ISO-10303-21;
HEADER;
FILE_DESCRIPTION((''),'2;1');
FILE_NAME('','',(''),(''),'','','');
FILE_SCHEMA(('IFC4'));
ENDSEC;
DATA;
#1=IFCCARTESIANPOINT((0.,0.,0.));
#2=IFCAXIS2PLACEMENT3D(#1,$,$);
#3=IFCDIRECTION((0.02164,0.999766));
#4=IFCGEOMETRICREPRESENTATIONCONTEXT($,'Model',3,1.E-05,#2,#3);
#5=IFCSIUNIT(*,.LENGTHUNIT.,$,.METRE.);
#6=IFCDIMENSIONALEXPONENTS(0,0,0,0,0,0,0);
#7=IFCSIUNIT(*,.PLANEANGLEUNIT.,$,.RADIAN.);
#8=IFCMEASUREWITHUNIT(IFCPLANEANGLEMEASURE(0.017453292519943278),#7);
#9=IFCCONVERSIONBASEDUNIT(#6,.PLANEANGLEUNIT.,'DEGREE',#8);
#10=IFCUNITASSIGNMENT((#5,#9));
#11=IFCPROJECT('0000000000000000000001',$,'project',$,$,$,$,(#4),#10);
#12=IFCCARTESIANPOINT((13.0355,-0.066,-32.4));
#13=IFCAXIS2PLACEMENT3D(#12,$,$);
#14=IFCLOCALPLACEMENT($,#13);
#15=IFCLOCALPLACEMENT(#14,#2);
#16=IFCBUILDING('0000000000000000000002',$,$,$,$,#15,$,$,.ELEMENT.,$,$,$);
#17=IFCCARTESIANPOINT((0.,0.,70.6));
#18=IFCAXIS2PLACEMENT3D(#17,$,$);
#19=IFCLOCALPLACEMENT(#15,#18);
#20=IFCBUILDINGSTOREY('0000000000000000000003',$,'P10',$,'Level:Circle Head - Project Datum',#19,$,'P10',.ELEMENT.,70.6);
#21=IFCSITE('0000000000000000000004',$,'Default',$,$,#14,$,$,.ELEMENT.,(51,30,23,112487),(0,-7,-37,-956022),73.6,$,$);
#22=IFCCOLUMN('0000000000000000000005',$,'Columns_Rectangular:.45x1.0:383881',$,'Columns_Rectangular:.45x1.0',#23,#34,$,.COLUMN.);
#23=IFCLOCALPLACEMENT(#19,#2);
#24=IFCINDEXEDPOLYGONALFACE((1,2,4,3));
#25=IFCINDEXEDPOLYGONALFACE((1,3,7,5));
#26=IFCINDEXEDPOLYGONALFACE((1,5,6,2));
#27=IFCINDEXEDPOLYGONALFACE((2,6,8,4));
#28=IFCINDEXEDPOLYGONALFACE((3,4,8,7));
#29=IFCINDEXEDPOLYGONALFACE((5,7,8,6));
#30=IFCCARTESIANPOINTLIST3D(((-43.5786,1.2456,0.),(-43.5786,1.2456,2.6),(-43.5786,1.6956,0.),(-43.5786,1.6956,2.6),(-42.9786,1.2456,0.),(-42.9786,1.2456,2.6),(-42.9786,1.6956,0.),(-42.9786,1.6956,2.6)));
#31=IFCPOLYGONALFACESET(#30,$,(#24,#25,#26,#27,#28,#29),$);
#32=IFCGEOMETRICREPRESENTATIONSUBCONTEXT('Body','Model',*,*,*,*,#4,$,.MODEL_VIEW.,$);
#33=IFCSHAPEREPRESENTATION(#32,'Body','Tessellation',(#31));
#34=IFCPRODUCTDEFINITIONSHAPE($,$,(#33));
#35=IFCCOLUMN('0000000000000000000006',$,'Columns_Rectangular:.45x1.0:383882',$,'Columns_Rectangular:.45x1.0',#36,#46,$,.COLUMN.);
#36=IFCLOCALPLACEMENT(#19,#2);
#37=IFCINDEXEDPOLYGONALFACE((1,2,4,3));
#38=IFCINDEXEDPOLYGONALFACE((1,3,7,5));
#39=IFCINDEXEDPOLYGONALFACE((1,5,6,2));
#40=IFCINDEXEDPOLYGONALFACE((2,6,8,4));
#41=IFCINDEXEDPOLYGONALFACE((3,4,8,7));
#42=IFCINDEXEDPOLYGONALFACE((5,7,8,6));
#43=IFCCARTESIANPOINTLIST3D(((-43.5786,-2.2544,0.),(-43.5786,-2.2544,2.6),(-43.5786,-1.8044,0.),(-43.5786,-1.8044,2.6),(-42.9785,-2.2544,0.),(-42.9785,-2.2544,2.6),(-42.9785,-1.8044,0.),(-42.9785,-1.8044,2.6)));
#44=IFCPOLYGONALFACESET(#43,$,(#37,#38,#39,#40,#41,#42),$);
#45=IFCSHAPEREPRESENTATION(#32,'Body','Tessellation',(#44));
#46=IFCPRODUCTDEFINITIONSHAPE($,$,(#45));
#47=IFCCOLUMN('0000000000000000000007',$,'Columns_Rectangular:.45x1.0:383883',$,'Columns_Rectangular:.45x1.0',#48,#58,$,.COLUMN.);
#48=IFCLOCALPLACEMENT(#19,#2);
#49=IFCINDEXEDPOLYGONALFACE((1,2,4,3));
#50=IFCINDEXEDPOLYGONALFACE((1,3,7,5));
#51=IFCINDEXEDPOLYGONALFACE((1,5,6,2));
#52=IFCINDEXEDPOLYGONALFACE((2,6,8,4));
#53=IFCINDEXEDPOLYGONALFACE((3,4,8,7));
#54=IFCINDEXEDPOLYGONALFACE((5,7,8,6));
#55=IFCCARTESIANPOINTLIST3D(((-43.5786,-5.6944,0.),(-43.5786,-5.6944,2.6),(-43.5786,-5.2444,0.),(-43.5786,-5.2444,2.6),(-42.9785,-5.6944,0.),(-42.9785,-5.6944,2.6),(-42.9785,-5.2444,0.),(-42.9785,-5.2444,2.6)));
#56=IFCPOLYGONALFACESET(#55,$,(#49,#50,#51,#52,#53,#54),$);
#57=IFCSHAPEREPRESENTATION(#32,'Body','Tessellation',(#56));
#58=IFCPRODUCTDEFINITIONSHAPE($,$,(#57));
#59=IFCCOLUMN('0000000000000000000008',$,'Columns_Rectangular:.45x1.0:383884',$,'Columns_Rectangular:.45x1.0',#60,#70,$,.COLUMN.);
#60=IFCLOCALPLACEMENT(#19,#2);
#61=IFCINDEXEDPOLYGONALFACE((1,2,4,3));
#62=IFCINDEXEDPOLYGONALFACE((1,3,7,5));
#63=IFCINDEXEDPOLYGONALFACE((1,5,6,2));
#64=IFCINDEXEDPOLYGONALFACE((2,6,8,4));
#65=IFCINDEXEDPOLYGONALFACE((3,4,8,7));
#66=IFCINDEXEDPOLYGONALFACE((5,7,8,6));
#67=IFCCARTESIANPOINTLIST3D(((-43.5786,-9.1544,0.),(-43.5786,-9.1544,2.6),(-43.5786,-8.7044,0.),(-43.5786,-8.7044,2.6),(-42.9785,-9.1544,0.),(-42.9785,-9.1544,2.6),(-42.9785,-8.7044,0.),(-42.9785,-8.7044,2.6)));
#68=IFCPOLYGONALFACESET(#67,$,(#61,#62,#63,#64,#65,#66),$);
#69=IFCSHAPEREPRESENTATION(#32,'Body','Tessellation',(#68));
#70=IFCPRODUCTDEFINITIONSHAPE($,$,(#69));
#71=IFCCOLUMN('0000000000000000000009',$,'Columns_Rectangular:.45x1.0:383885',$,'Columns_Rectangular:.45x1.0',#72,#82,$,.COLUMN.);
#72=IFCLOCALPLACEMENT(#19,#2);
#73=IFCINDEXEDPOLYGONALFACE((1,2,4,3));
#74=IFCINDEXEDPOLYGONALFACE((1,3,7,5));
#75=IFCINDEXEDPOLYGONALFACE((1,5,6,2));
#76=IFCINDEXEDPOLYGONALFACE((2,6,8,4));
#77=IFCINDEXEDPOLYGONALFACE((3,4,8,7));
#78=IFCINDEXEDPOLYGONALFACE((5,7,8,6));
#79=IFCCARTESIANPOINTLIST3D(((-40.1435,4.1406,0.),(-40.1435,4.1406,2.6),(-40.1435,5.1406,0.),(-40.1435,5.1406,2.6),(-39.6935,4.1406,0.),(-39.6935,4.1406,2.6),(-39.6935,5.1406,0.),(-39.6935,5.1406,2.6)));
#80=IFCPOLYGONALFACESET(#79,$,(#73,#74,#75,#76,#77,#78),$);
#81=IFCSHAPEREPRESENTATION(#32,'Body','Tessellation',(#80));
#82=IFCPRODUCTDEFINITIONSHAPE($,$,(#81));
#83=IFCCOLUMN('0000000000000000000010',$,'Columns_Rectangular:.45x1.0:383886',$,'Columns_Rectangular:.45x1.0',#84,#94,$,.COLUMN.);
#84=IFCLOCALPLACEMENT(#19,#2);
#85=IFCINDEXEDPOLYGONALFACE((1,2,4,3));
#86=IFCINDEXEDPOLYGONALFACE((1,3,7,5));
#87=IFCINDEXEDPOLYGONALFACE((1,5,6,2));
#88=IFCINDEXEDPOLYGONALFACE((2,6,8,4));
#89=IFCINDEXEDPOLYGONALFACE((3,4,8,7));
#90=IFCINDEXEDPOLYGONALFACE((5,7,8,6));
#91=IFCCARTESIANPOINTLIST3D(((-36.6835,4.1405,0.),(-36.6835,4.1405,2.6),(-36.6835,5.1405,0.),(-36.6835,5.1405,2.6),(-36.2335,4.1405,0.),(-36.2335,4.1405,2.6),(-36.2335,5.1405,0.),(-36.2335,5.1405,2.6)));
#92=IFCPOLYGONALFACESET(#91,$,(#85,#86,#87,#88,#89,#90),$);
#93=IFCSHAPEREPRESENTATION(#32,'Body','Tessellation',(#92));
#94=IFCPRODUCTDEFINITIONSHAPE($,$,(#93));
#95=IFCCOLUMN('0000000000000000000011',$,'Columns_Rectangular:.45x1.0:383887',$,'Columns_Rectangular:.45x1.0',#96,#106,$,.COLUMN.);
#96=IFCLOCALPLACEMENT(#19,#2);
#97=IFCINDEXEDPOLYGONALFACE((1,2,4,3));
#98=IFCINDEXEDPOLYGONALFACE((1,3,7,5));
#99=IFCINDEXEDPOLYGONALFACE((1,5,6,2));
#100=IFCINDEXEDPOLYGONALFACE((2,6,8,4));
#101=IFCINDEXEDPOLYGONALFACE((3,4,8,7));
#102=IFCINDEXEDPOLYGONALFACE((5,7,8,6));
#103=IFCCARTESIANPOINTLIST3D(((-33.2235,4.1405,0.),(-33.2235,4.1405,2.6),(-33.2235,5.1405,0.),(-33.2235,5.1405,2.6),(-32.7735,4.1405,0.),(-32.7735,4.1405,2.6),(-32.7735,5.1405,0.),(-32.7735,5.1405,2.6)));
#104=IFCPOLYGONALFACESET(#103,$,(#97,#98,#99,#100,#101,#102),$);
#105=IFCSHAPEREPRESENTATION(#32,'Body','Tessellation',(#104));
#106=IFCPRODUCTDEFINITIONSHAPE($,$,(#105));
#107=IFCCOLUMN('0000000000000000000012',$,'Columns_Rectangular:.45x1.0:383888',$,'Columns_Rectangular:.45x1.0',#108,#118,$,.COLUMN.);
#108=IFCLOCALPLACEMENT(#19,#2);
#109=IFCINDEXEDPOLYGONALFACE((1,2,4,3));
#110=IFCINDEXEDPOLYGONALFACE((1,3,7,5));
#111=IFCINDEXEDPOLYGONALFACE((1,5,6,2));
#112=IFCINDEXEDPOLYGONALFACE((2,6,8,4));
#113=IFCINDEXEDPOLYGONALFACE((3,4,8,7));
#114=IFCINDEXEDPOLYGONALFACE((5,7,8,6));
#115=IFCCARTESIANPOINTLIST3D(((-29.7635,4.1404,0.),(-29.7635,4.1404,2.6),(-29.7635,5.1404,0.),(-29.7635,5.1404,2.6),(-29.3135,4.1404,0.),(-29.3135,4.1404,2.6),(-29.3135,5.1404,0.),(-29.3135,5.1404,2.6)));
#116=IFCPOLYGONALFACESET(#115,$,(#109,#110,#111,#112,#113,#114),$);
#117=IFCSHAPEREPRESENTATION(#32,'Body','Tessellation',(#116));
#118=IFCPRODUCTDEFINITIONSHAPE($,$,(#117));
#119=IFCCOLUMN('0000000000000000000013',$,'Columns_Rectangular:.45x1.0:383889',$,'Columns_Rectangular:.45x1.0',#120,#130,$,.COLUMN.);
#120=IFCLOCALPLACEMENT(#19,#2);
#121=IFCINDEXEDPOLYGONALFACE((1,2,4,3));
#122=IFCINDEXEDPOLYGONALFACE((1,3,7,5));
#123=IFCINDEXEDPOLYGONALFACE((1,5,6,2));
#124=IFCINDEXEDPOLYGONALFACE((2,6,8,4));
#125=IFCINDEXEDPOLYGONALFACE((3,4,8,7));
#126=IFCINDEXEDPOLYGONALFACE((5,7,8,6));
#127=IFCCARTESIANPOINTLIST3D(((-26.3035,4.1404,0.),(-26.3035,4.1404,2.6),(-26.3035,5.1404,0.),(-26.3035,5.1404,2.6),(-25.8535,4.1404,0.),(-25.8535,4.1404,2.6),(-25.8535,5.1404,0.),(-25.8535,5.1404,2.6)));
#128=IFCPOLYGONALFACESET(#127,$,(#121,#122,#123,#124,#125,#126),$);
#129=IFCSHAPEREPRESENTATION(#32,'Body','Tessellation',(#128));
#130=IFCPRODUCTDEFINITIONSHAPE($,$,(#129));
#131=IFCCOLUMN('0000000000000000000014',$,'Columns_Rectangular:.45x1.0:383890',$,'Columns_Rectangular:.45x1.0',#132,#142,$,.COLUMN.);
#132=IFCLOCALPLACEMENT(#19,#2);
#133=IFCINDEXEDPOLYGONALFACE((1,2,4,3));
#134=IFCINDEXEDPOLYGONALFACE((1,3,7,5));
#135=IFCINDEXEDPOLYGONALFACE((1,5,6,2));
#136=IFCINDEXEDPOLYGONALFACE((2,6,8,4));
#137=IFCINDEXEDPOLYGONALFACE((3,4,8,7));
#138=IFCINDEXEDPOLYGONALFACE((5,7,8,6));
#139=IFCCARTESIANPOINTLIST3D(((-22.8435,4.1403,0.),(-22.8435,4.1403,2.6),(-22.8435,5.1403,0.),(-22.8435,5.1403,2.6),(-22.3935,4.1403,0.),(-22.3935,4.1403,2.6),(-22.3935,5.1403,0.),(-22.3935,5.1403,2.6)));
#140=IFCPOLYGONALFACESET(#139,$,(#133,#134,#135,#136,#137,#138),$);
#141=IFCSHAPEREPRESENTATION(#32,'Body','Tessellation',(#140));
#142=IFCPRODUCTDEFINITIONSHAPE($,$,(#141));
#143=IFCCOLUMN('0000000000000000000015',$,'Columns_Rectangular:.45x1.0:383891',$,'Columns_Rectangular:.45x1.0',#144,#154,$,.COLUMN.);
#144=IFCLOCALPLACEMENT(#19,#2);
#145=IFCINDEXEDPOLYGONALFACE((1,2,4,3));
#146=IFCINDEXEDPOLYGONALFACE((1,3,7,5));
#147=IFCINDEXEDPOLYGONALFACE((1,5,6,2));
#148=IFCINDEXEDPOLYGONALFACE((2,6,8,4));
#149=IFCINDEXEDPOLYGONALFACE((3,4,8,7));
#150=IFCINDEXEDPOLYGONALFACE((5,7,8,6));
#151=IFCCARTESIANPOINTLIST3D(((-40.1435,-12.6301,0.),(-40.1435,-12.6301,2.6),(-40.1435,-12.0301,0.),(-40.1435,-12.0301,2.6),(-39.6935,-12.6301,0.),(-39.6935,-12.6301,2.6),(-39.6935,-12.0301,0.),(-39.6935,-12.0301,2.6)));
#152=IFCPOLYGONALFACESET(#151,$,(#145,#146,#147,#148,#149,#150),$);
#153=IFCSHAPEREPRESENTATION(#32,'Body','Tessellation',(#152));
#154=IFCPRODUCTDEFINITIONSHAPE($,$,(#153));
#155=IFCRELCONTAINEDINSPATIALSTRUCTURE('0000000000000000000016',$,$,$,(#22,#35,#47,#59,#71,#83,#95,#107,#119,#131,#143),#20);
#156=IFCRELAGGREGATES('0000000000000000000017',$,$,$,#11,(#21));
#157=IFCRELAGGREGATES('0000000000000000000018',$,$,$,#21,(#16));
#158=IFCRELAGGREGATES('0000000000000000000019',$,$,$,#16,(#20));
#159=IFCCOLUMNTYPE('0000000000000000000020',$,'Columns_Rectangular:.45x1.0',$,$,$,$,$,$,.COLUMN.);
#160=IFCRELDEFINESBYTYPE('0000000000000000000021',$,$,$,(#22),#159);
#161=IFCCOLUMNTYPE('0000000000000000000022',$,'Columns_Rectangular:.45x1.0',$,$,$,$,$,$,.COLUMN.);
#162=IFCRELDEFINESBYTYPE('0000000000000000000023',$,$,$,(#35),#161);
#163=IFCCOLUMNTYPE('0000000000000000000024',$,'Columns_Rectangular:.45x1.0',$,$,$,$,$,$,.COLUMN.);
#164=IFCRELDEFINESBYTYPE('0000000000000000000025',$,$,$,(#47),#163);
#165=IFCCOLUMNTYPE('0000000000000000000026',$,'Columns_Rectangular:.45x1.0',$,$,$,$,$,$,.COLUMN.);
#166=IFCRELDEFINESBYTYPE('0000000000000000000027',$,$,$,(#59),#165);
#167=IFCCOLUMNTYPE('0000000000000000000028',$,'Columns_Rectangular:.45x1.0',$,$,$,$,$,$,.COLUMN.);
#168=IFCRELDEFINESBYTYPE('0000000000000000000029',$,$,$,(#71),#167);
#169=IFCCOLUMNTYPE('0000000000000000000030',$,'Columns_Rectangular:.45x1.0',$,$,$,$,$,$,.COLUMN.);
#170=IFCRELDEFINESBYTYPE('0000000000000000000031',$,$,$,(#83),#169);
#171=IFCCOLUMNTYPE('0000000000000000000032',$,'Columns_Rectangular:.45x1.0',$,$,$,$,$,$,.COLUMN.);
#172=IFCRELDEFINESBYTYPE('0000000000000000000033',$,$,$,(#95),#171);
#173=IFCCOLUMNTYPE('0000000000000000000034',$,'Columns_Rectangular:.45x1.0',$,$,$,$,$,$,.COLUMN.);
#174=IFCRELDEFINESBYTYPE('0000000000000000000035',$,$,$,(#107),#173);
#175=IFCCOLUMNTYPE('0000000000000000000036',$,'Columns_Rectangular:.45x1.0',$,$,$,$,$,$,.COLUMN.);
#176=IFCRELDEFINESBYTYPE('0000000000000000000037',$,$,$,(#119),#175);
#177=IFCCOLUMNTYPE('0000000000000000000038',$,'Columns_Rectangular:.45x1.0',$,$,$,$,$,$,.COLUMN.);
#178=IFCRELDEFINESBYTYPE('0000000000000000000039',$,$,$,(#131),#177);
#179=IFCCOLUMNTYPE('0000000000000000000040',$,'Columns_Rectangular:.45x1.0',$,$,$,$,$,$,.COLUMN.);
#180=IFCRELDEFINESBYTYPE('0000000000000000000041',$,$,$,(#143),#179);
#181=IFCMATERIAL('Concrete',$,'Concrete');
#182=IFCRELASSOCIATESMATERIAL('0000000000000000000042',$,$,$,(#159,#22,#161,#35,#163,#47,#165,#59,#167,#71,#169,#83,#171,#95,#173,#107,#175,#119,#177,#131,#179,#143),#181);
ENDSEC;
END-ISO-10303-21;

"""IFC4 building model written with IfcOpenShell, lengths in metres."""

from ifc_helpers import new_model, entity, si_unit, converted_unit, direction, frame, origin, place, context, subcontext, project, spatial, indexed_curve, outline, extrude, source, transform, mapped, material, type_object, type_shapes, element, save


model = new_model("IFC4")

# Units and contexts
model_context = context("Model", 3, precision=1e-05, world=origin(), true_north=direction((0.02164, 0.999766)))
body_context = subcontext(model_context, "Body", "Model", "MODEL_VIEW")
ifc_project = project(units=[si_unit("LENGTHUNIT", "METRE"), converted_unit("PLANEANGLEUNIT", "DEGREE", entity("IfcPlaneAngleMeasure", 0.017453292519943278), si_unit("PLANEANGLEUNIT", "RADIAN"), dimensions=[0, 0, 0, 0, 0, 0, 0])], contexts=[model_context])

# Site, building, storey
site_placement = place(None, frame((13.0355, -0.066, -32.4)))
site = spatial("IfcSite", under=ifc_project, at=site_placement, Name="Default", CompositionType="ELEMENT", RefLatitude=(51, 30, 23, 112487), RefLongitude=(0, -7, -37, -956022), RefElevation=73.6)
building_placement = place(site_placement, origin())
building = spatial("IfcBuilding", under=site, at=building_placement, CompositionType="ELEMENT")
storey_placement = place(building_placement, frame((0.0, 0.0, 70.6)))
storey = spatial("IfcBuildingStorey", under=building, at=storey_placement, Name="P10", ObjectType="Level:Circle Head - Project Datum", LongName="P10", CompositionType="ELEMENT", Elevation=70.6)

# Columns
ifc_material = material(Name="Concrete", Category="Concrete")
column_type_1 = type_object("IfcColumnType", Name="Columns_Rectangular:.45x1.0", PredefinedType="COLUMN", material=ifc_material)
shared_shape_1 = source(origin(), body_context, "Body", "SweptSolid", [
    extrude(outline(indexed_curve([(-0.3, -0.225), (0.3, -0.225), (0.3, 0.225), (-0.3, 0.225), (-0.3, -0.225)], self_intersect=False)), frame((-43.2786, 1.4706, 70.6)), (0.0, 0.0, 1.0), 2.6),
])
type_shapes(column_type_1, [shared_shape_1])
column_1_placement = place(storey_placement, frame((0.0, 0.0, -70.6)))
element("IfcColumn", 1, at=column_1_placement, inside=storey, type_object=column_type_1, material=ifc_material, Name="Columns_Rectangular:.45x1.0:383881", ObjectType="Columns_Rectangular:.45x1.0", PredefinedType="COLUMN", context=body_context, shape_type="MappedRepresentation", body=[
    mapped(shared_shape_1, transform((0.0, 0.0, 0.0), scale=1.0)),
])
column_type_2 = type_object("IfcColumnType", Name="Columns_Rectangular:.45x1.0", PredefinedType="COLUMN", material=ifc_material)
shared_shape_2 = source(origin(), body_context, "Body", "SweptSolid", [
    extrude(outline(indexed_curve([(-0.3, -0.225), (0.3, -0.225), (0.3, 0.225), (-0.3, 0.225), (-0.3, -0.225)], self_intersect=False)), frame((-43.2785, -2.0294, 70.6)), (0.0, 0.0, 1.0), 2.6),
])
type_shapes(column_type_2, [shared_shape_2])
column_2_placement = place(storey_placement, frame((0.0, 0.0, -70.6)))
element("IfcColumn", 2, at=column_2_placement, inside=storey, type_object=column_type_2, material=ifc_material, Name="Columns_Rectangular:.45x1.0:383882", ObjectType="Columns_Rectangular:.45x1.0", PredefinedType="COLUMN", context=body_context, shape_type="MappedRepresentation", body=[
    mapped(shared_shape_2, transform((0.0, 0.0, 0.0), scale=1.0)),
])
column_type_3 = type_object("IfcColumnType", Name="Columns_Rectangular:.45x1.0", PredefinedType="COLUMN", material=ifc_material)
shared_shape_3 = source(origin(), body_context, "Body", "SweptSolid", [
    extrude(outline(indexed_curve([(-0.3, -0.225), (0.3, -0.225), (0.3, 0.225), (-0.3, 0.225), (-0.3, -0.225)], self_intersect=False)), frame((-43.2785, -5.4694, 70.6)), (0.0, 0.0, 1.0), 2.6),
])
type_shapes(column_type_3, [shared_shape_3])
column_3_placement = place(storey_placement, frame((0.0, 0.0, -70.6)))
element("IfcColumn", 3, at=column_3_placement, inside=storey, type_object=column_type_3, material=ifc_material, Name="Columns_Rectangular:.45x1.0:383883", ObjectType="Columns_Rectangular:.45x1.0", PredefinedType="COLUMN", context=body_context, shape_type="MappedRepresentation", body=[
    mapped(shared_shape_3, transform((0.0, 0.0, 0.0), scale=1.0)),
])
column_type_4 = type_object("IfcColumnType", Name="Columns_Rectangular:.45x1.0", PredefinedType="COLUMN", material=ifc_material)
shared_shape_4 = source(origin(), body_context, "Body", "SweptSolid", [
    extrude(outline(indexed_curve([(-0.3, -0.225), (0.3, -0.225), (0.3, 0.225), (-0.3, 0.225), (-0.3, -0.225)], self_intersect=False)), frame((-43.2785, -8.9294, 70.6)), (0.0, 0.0, 1.0), 2.6),
])
type_shapes(column_type_4, [shared_shape_4])
column_4_placement = place(storey_placement, frame((0.0, 0.0, -70.6)))
element("IfcColumn", 4, at=column_4_placement, inside=storey, type_object=column_type_4, material=ifc_material, Name="Columns_Rectangular:.45x1.0:383884", ObjectType="Columns_Rectangular:.45x1.0", PredefinedType="COLUMN", context=body_context, shape_type="MappedRepresentation", body=[
    mapped(shared_shape_4, transform((0.0, 0.0, 0.0), scale=1.0)),
])
column_type_5 = type_object("IfcColumnType", Name="Columns_Rectangular:.45x1.0", PredefinedType="COLUMN", material=ifc_material)
shared_shape_5 = source(origin(), body_context, "Body", "SweptSolid", [
    extrude(outline(indexed_curve([(-0.5, -0.225), (0.5, -0.225), (0.5, 0.225), (-0.5, 0.225), (-0.5, -0.225)], self_intersect=False)), frame((-39.9185, 4.6406, 70.6), z_axis=(0.0, 0.0, 1.0), x_axis=(0.000016, 1.0, 0.0)), (0.0, 0.0, 1.0), 2.6),
])
type_shapes(column_type_5, [shared_shape_5])
column_5_placement = place(storey_placement, frame((0.0, 0.0, -70.6)))
element("IfcColumn", 5, at=column_5_placement, inside=storey, type_object=column_type_5, material=ifc_material, Name="Columns_Rectangular:.45x1.0:383885", ObjectType="Columns_Rectangular:.45x1.0", PredefinedType="COLUMN", context=body_context, shape_type="MappedRepresentation", body=[
    mapped(shared_shape_5, transform((0.0, 0.0, 0.0), scale=1.0)),
])
column_type_6 = type_object("IfcColumnType", Name="Columns_Rectangular:.45x1.0", PredefinedType="COLUMN", material=ifc_material)
shared_shape_6 = source(origin(), body_context, "Body", "SweptSolid", [
    extrude(outline(indexed_curve([(-0.5, -0.225), (0.5, -0.225), (0.5, 0.225), (-0.5, 0.225), (-0.5, -0.225)], self_intersect=False)), frame((-36.4585, 4.6405, 70.6), z_axis=(0.0, 0.0, 1.0), x_axis=(0.000016, 1.0, 0.0)), (0.0, 0.0, 1.0), 2.6),
])
type_shapes(column_type_6, [shared_shape_6])
column_6_placement = place(storey_placement, frame((0.0, 0.0, -70.6)))
element("IfcColumn", 6, at=column_6_placement, inside=storey, type_object=column_type_6, material=ifc_material, Name="Columns_Rectangular:.45x1.0:383886", ObjectType="Columns_Rectangular:.45x1.0", PredefinedType="COLUMN", context=body_context, shape_type="MappedRepresentation", body=[
    mapped(shared_shape_6, transform((0.0, 0.0, 0.0), scale=1.0)),
])
column_type_7 = type_object("IfcColumnType", Name="Columns_Rectangular:.45x1.0", PredefinedType="COLUMN", material=ifc_material)
shared_shape_7 = source(origin(), body_context, "Body", "SweptSolid", [
    extrude(outline(indexed_curve([(-0.5, -0.225), (0.5, -0.225), (0.5, 0.225), (-0.5, 0.225), (-0.5, -0.225)], self_intersect=False)), frame((-32.9985, 4.6405, 70.6), z_axis=(0.0, 0.0, 1.0), x_axis=(0.000016, 1.0, 0.0)), (0.0, 0.0, 1.0), 2.6),
])
type_shapes(column_type_7, [shared_shape_7])
column_7_placement = place(storey_placement, frame((0.0, 0.0, -70.6)))
element("IfcColumn", 7, at=column_7_placement, inside=storey, type_object=column_type_7, material=ifc_material, Name="Columns_Rectangular:.45x1.0:383887", ObjectType="Columns_Rectangular:.45x1.0", PredefinedType="COLUMN", context=body_context, shape_type="MappedRepresentation", body=[
    mapped(shared_shape_7, transform((0.0, 0.0, 0.0), scale=1.0)),
])
column_type_8 = type_object("IfcColumnType", Name="Columns_Rectangular:.45x1.0", PredefinedType="COLUMN", material=ifc_material)
shared_shape_8 = source(origin(), body_context, "Body", "SweptSolid", [
    extrude(outline(indexed_curve([(-0.5, -0.225), (0.5, -0.225), (0.5, 0.225), (-0.5, 0.225), (-0.5, -0.225)], self_intersect=False)), frame((-29.5385, 4.6404, 70.6), z_axis=(0.0, 0.0, 1.0), x_axis=(0.000016, 1.0, 0.0)), (0.0, 0.0, 1.0), 2.6),
])
type_shapes(column_type_8, [shared_shape_8])
column_8_placement = place(storey_placement, frame((0.0, 0.0, -70.6)))
element("IfcColumn", 8, at=column_8_placement, inside=storey, type_object=column_type_8, material=ifc_material, Name="Columns_Rectangular:.45x1.0:383888", ObjectType="Columns_Rectangular:.45x1.0", PredefinedType="COLUMN", context=body_context, shape_type="MappedRepresentation", body=[
    mapped(shared_shape_8, transform((0.0, 0.0, 0.0), scale=1.0)),
])
column_type_9 = type_object("IfcColumnType", Name="Columns_Rectangular:.45x1.0", PredefinedType="COLUMN", material=ifc_material)
shared_shape_9 = source(origin(), body_context, "Body", "SweptSolid", [
    extrude(outline(indexed_curve([(-0.5, -0.225), (0.5, -0.225), (0.5, 0.225), (-0.5, 0.225), (-0.5, -0.225)], self_intersect=False)), frame((-26.0785, 4.6404, 70.6), z_axis=(0.0, 0.0, 1.0), x_axis=(0.000016, 1.0, 0.0)), (0.0, 0.0, 1.0), 2.6),
])
type_shapes(column_type_9, [shared_shape_9])
column_9_placement = place(storey_placement, frame((0.0, 0.0, -70.6)))
element("IfcColumn", 9, at=column_9_placement, inside=storey, type_object=column_type_9, material=ifc_material, Name="Columns_Rectangular:.45x1.0:383889", ObjectType="Columns_Rectangular:.45x1.0", PredefinedType="COLUMN", context=body_context, shape_type="MappedRepresentation", body=[
    mapped(shared_shape_9, transform((0.0, 0.0, 0.0), scale=1.0)),
])
column_type_10 = type_object("IfcColumnType", Name="Columns_Rectangular:.45x1.0", PredefinedType="COLUMN", material=ifc_material)
shared_shape_10 = source(origin(), body_context, "Body", "SweptSolid", [
    extrude(outline(indexed_curve([(-0.5, -0.225), (0.5, -0.225), (0.5, 0.225), (-0.5, 0.225), (-0.5, -0.225)], self_intersect=False)), frame((-22.6185, 4.6403, 70.6), z_axis=(0.0, 0.0, 1.0), x_axis=(0.000016, 1.0, 0.0)), (0.0, 0.0, 1.0), 2.6),
])
type_shapes(column_type_10, [shared_shape_10])
column_10_placement = place(storey_placement, frame((0.0, 0.0, -70.6)))
element("IfcColumn", 10, at=column_10_placement, inside=storey, type_object=column_type_10, material=ifc_material, Name="Columns_Rectangular:.45x1.0:383890", ObjectType="Columns_Rectangular:.45x1.0", PredefinedType="COLUMN", context=body_context, shape_type="MappedRepresentation", body=[
    mapped(shared_shape_10, transform((0.0, 0.0, 0.0), scale=1.0)),
])
column_type_11 = type_object("IfcColumnType", Name="Columns_Rectangular:.45x1.0", PredefinedType="COLUMN", material=ifc_material)
shared_shape_11 = source(origin(), body_context, "Body", "SweptSolid", [
    extrude(outline(indexed_curve([(-0.3, -0.225), (0.3, -0.225), (0.3, 0.225), (-0.3, 0.225), (-0.3, -0.225)], self_intersect=False)), frame((-39.9185, -12.3301, 70.6), z_axis=(0.0, 0.0, 1.0), x_axis=(0.000011, 1.0, 0.0)), (0.0, 0.0, 1.0), 2.6),
])
type_shapes(column_type_11, [shared_shape_11])
column_11_placement = place(storey_placement, frame((0.0, 0.0, -70.6)))
element("IfcColumn", 11, at=column_11_placement, inside=storey, type_object=column_type_11, material=ifc_material, Name="Columns_Rectangular:.45x1.0:383891", ObjectType="Columns_Rectangular:.45x1.0", PredefinedType="COLUMN", context=body_context, shape_type="MappedRepresentation", body=[
    mapped(shared_shape_11, transform((0.0, 0.0, 0.0), scale=1.0)),
])

save(model, "model.ifc")
